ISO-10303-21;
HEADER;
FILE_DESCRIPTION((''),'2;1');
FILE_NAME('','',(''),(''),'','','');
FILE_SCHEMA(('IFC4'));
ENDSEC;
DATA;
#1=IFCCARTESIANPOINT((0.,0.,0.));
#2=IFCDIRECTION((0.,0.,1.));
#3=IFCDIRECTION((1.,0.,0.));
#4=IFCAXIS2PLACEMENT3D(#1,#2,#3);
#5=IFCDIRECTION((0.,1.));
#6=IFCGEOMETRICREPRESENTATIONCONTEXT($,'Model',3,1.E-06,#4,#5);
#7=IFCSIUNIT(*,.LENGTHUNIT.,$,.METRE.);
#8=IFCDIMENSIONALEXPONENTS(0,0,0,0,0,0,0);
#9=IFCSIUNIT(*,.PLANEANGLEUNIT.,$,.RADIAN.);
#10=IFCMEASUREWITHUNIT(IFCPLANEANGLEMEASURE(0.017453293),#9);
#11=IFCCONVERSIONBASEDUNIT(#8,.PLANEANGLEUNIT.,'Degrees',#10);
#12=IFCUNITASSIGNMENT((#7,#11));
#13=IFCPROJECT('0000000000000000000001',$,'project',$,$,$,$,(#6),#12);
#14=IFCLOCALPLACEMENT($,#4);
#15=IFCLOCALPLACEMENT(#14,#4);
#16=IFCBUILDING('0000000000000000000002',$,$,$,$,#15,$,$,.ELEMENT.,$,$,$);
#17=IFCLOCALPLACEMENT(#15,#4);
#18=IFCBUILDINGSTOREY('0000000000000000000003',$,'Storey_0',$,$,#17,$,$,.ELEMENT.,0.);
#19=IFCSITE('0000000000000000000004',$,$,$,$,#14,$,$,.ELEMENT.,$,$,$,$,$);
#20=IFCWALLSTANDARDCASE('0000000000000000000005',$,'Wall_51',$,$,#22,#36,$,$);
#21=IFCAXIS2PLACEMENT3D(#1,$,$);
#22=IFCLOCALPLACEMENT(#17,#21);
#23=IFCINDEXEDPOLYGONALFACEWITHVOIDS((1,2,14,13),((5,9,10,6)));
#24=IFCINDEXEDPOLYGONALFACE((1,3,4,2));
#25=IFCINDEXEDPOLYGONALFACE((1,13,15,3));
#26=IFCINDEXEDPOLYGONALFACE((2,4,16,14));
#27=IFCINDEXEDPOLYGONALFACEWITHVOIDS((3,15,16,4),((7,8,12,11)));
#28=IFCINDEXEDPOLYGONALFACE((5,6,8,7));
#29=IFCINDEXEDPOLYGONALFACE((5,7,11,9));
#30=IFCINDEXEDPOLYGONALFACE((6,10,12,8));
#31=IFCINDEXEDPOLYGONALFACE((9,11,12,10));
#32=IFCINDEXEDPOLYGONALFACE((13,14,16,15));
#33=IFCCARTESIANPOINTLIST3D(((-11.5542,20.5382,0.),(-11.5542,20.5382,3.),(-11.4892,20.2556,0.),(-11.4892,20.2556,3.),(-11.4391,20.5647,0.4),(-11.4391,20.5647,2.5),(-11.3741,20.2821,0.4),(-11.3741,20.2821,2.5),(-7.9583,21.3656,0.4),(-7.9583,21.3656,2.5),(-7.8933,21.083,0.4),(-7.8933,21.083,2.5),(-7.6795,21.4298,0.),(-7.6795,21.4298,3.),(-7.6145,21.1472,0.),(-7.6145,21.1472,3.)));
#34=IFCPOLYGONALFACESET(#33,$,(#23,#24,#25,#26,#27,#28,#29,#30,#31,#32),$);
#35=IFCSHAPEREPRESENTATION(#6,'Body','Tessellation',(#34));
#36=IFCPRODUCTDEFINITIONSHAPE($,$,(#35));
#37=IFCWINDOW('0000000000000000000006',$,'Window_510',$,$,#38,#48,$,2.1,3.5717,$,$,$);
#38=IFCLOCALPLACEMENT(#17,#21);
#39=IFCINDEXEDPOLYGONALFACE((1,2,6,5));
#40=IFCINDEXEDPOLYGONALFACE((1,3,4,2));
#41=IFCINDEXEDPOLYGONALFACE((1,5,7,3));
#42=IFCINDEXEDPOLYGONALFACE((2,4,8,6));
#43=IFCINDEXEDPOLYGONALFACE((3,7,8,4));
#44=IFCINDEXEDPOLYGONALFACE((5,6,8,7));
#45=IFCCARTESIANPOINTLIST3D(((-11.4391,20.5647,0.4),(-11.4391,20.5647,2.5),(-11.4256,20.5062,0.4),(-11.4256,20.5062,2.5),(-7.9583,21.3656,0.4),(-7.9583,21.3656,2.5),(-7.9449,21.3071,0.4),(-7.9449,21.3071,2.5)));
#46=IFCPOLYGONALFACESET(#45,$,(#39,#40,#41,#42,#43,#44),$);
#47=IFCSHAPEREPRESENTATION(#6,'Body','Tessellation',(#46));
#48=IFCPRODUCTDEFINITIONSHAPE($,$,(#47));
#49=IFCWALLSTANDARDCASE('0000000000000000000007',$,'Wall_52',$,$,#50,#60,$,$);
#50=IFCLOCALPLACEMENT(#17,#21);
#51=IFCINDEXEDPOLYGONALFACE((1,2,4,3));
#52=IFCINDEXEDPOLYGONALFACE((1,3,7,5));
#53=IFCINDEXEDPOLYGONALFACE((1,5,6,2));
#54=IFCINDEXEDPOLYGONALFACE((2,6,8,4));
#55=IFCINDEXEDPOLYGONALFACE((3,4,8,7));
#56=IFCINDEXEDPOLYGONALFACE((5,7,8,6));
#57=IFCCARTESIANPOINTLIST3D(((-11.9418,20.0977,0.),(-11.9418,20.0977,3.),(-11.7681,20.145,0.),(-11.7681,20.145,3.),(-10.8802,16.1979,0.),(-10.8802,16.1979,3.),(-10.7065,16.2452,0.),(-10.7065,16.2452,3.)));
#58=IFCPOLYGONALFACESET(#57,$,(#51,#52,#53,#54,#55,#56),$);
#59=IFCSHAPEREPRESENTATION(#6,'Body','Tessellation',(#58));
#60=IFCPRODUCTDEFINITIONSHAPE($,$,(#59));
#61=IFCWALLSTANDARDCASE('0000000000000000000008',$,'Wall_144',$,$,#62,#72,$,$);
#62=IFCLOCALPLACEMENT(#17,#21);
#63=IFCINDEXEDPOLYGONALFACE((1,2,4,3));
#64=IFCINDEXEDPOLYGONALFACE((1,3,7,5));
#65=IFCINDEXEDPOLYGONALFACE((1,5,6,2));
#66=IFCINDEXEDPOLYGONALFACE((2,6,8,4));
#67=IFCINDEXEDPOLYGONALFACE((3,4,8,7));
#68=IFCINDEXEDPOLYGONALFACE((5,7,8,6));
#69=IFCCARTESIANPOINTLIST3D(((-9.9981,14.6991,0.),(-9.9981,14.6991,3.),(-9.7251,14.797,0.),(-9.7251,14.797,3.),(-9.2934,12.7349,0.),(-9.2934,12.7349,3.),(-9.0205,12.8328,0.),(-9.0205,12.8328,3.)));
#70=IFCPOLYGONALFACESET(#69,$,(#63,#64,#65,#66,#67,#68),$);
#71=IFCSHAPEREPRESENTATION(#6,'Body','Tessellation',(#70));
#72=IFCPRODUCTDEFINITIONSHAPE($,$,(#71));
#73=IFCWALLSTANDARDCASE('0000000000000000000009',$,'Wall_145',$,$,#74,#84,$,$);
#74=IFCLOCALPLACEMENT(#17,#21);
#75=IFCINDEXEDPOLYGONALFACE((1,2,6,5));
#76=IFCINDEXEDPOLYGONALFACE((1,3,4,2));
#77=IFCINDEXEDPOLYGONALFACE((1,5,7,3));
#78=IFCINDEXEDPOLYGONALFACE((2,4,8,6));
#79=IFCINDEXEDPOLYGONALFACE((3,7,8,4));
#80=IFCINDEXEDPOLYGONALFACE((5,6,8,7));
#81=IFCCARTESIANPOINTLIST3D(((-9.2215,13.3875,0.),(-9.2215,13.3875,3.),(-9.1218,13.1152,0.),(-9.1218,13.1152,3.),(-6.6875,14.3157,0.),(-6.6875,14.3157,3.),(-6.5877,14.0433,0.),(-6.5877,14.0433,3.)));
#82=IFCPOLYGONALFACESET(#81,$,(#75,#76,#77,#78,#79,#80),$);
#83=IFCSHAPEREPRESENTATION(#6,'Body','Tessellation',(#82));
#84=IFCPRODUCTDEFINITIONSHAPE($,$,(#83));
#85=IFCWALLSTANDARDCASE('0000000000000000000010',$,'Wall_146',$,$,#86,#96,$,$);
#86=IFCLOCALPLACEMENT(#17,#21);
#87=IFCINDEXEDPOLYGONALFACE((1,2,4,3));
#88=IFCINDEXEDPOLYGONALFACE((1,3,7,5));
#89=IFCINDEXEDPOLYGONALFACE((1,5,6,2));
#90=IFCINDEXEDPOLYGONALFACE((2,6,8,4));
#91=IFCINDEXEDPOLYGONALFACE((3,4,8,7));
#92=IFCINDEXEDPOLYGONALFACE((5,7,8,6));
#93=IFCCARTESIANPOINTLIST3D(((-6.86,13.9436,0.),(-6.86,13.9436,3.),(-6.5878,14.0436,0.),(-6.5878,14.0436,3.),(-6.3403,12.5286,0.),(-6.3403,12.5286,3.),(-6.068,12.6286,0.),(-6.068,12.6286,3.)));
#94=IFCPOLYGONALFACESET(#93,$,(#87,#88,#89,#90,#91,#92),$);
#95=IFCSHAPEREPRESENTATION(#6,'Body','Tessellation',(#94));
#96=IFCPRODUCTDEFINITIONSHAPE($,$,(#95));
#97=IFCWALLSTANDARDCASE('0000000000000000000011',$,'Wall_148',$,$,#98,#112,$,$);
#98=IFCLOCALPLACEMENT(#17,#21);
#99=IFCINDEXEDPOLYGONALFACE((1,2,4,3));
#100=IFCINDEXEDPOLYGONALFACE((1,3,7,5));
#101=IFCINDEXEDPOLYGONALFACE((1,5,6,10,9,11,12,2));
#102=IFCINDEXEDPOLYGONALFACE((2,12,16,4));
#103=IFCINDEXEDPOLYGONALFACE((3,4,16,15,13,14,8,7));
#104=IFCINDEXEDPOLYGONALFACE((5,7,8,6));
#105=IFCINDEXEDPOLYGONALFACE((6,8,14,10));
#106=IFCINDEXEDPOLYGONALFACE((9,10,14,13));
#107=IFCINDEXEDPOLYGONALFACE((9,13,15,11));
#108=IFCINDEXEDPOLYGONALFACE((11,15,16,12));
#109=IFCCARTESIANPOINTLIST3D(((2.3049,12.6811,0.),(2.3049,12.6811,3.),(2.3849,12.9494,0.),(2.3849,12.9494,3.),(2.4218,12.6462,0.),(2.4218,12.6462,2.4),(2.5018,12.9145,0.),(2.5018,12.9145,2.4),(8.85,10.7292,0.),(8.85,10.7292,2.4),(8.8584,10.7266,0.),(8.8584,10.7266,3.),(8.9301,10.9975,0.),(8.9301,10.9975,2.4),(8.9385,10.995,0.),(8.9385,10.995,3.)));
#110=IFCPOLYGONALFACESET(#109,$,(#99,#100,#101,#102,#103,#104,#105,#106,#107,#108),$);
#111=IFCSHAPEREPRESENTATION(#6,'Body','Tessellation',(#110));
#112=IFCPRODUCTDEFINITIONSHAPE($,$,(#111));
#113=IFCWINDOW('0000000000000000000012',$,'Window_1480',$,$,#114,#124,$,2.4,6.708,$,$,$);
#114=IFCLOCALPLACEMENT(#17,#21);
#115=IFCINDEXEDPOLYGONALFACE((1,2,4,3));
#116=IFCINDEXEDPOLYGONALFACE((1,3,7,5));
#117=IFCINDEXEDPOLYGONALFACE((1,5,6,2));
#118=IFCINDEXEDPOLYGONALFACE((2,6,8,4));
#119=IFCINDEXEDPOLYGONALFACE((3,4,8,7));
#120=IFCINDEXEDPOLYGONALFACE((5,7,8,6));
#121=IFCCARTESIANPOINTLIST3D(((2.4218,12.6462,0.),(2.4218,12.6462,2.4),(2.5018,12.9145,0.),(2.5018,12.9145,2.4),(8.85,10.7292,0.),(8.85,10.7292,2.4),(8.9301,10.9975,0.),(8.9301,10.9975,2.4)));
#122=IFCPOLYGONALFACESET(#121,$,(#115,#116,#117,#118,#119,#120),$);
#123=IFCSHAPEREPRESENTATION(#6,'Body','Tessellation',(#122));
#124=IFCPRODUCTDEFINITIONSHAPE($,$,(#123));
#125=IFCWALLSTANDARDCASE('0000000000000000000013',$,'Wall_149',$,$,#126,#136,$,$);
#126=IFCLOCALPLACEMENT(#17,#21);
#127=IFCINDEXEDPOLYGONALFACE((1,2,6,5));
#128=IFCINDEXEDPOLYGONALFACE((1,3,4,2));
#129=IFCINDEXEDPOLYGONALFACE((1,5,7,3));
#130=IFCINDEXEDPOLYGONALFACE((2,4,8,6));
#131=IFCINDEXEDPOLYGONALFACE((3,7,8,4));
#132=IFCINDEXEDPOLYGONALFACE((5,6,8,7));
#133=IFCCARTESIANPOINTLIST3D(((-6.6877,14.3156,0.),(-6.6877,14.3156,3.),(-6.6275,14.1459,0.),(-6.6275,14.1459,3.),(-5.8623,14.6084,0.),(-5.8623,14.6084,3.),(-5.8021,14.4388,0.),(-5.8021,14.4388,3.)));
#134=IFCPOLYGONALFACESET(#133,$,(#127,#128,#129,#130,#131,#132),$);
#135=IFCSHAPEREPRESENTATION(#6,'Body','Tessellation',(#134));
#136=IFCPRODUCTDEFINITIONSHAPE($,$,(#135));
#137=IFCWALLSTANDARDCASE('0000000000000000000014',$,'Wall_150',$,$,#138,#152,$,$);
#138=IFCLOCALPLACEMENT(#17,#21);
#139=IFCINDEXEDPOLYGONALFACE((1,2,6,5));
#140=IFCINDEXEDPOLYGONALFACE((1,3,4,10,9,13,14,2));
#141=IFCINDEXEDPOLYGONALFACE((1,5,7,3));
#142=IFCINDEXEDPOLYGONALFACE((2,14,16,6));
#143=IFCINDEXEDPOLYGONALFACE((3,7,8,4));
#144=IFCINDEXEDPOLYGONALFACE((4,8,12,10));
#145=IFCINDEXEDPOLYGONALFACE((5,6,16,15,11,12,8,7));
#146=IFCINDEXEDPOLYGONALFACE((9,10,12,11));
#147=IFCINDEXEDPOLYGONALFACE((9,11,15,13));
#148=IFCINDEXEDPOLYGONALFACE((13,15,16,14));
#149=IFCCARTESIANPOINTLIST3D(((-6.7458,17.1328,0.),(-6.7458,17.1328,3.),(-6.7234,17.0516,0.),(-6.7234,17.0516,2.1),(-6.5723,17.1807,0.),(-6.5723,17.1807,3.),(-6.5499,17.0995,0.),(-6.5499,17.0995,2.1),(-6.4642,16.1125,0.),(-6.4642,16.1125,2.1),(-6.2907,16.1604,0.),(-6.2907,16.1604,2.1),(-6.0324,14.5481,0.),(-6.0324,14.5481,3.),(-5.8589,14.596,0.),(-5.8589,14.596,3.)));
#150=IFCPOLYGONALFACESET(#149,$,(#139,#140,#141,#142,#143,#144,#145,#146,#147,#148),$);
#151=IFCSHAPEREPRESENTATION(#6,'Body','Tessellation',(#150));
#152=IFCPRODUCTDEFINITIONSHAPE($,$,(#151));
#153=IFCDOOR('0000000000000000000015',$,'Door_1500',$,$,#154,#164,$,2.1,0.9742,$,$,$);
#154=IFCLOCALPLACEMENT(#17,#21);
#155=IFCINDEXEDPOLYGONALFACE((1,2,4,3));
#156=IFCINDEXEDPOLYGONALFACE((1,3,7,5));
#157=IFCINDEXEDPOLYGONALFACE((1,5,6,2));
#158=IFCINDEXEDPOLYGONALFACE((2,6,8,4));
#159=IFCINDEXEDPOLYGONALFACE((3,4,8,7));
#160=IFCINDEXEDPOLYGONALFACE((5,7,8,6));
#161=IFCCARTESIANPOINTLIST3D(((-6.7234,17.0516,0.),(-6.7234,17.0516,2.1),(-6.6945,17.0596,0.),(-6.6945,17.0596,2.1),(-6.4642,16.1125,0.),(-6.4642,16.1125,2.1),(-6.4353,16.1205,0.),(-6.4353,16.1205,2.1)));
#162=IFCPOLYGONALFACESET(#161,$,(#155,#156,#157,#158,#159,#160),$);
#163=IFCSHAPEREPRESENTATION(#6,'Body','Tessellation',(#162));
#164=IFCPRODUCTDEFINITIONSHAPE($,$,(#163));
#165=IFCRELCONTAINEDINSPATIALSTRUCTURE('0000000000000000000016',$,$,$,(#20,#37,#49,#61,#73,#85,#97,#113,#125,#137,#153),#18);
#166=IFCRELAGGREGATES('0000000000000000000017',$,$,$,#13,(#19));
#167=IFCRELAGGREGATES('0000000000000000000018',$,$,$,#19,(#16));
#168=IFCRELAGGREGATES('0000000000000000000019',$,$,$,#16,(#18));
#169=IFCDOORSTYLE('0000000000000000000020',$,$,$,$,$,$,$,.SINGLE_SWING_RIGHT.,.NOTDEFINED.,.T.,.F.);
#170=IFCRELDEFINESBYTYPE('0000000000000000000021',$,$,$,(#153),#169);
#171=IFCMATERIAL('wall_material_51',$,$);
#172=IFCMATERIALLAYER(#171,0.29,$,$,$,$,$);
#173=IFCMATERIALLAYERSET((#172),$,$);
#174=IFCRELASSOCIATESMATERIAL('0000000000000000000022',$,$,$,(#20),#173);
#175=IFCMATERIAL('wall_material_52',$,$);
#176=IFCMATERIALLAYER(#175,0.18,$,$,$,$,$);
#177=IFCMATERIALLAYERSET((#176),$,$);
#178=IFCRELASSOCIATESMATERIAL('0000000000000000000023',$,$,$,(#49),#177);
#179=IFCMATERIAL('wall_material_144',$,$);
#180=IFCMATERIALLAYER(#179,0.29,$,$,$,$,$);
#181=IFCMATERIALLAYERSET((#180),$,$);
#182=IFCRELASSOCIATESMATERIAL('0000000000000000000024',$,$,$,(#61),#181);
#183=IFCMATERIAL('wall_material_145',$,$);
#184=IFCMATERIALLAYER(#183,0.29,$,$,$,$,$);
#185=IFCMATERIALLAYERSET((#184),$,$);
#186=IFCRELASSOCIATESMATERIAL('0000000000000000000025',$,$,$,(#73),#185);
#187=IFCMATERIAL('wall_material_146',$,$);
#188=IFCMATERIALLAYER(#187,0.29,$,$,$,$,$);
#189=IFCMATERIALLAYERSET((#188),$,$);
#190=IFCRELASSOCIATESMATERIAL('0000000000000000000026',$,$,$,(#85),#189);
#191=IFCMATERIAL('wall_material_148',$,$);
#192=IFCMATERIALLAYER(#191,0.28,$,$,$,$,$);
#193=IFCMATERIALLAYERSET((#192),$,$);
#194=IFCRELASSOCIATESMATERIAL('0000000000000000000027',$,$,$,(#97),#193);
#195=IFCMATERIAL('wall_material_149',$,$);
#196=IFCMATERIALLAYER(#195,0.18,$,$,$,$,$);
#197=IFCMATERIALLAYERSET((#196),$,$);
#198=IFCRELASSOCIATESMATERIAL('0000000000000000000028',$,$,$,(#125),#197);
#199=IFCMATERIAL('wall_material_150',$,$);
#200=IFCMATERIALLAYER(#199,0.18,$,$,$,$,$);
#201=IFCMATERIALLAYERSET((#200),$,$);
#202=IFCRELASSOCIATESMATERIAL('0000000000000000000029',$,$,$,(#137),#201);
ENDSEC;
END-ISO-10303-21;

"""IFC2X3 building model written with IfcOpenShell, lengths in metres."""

from ifc_helpers import new_model, entity, si_unit, converted_unit, direction, frame, frame_2d, origin_with_axes, place, context, project, spatial, polyline, rectangle, outline, extrude, material, layer, layer_set, layer_usage, type_object, element, fill, save


model = new_model("IFC2X3")

# Units and contexts
model_context = context("Model", 3, precision=1e-06, world=origin_with_axes(), true_north=direction((0.0, 1.0)))
ifc_project = project(units=[si_unit("LENGTHUNIT", "METRE"), converted_unit("PLANEANGLEUNIT", "Degrees", entity("IfcPlaneAngleMeasure", 0.017453293), si_unit("PLANEANGLEUNIT", "RADIAN"), dimensions=[0, 0, 0, 0, 0, 0, 0])], contexts=[model_context])

# Site, building, storey
site_placement = place(None, origin_with_axes())
site = spatial("IfcSite", under=ifc_project, at=site_placement, CompositionType="ELEMENT")
building_placement = place(site_placement, origin_with_axes())
building = spatial("IfcBuilding", under=site, at=building_placement, CompositionType="ELEMENT")
storey_placement = place(building_placement, origin_with_axes())
storey = spatial("IfcBuildingStorey", under=building, at=storey_placement, Name="Storey_0", CompositionType="ELEMENT", Elevation=0.0)

# Wall, opening, window
ifc_material_1 = material(Name="wall_material_51")
ifc_layer_1 = layer(ifc_material_1, 0.29)
ifc_layer_set_1 = layer_set([ifc_layer_1])
ifc_layer_usage_1 = layer_usage(ifc_layer_set_1, "AXIS2", "NEGATIVE", 0.0)
wall_1_placement = place(storey_placement, frame((-11.5542, 20.5382, 0.0), z_axis=(0.0, 0.0, 1.0), x_axis=(0.974534, 0.22424, 0.0)))
wall_1 = element("IfcWallStandardCase", 1, at=wall_1_placement, inside=storey, material=ifc_layer_usage_1, Name="Wall_51", context=model_context, shape_type="SweptSolid", body=[
    extrude(outline(polyline([(0.0, 0.0), (3.9759, 0.0), (3.9759, -0.29), (0.0, -0.29), (0.0, 0.0)])), origin_with_axes(), (0.0, 0.0, 1.0), 3.0),
])
opening_1_placement = place(wall_1_placement, frame((0.1181, 0.0, 0.4), z_axis=(0.0, 0.0, 1.0), x_axis=(1.0, 0.0, 0.0)))
opening_1 = element("IfcOpeningElement", 2, at=opening_1_placement, cuts=wall_1, context=model_context, shape_type="SweptSolid", body=[
    extrude(rectangle(XDim=3.5717, YDim=2.1, at=frame_2d((1.05, -1.7859), x_axis=(0.0, 1.0))), frame((0.0, 0.01, 0.0), z_axis=(0.0, -1.0, 0.0), x_axis=(0.0, 0.0, 1.0)), (0.0, 0.0, 1.0), 0.31),
])
window_1_placement = place(storey_placement, frame((0.0, 0.0, 0.4), z_axis=(0.0, 0.0, 1.0), x_axis=(1.0, 0.0, 0.0)))
window_1 = element("IfcWindow", 3, at=window_1_placement, inside=storey, Name="Window_510", OverallHeight=2.1, OverallWidth=3.5717, context=model_context, shape_type="SweptSolid", body=[
    extrude(outline(polyline([(-11.4391, 20.5647), (-7.9583, 21.3656), (-7.9449, 21.3071), (-11.4256, 20.5062), (-11.4391, 20.5647)])), origin_with_axes(), (0.0, 0.0, 1.0), 2.1),
])
fill(opening_1, window_1)

# Walls
ifc_material_2 = material(Name="wall_material_52")
ifc_layer_2 = layer(ifc_material_2, 0.18)
ifc_layer_set_2 = layer_set([ifc_layer_2])
ifc_layer_usage_2 = layer_usage(ifc_layer_set_2, "AXIS2", "POSITIVE", 0.0)
wall_2_placement = place(storey_placement, frame((-11.9418, 20.0977, 0.0), z_axis=(0.0, 0.0, 1.0), x_axis=(0.262665, -0.964887, 0.0)))
element("IfcWallStandardCase", 4, at=wall_2_placement, inside=storey, material=ifc_layer_usage_2, Name="Wall_52", context=model_context, shape_type="SweptSolid", body=[
    extrude(outline(polyline([(0.0, 0.18), (4.0417, 0.18), (4.0417, 0.0), (0.0, 0.0), (0.0, 0.18)])), origin_with_axes(), (0.0, 0.0, 1.0), 3.0),
])
ifc_material_3 = material(Name="wall_material_144")
ifc_layer_3 = layer(ifc_material_3, 0.29)
ifc_layer_set_3 = layer_set([ifc_layer_3])
ifc_layer_usage_3 = layer_usage(ifc_layer_set_3, "AXIS2", "NEGATIVE", 0.0)
wall_3_placement = place(storey_placement, frame((-9.7251, 14.797, 0.0), z_axis=(0.0, 0.0, 1.0), x_axis=(0.337694, -0.941256, 0.0)))
element("IfcWallStandardCase", 5, at=wall_3_placement, inside=storey, material=ifc_layer_usage_3, Name="Wall_144", context=model_context, shape_type="SweptSolid", body=[
    extrude(outline(polyline([(0.0, 0.0), (2.0867, 0.0), (2.0867, -0.29), (0.0, -0.29), (0.0, 0.0)])), origin_with_axes(), (0.0, 0.0, 1.0), 3.0),
])
ifc_material_4 = material(Name="wall_material_145")
ifc_layer_4 = layer(ifc_material_4, 0.29)
ifc_layer_set_4 = layer_set([ifc_layer_4])
ifc_layer_usage_4 = layer_usage(ifc_layer_set_4, "AXIS2", "NEGATIVE", 0.0)
wall_4_placement = place(storey_placement, frame((-9.2215, 13.3875, 0.0), z_axis=(0.0, 0.0, 1.0), x_axis=(0.939, 0.343918, 0.0)))
element("IfcWallStandardCase", 6, at=wall_4_placement, inside=storey, material=ifc_layer_usage_4, Name="Wall_145", context=model_context, shape_type="SweptSolid", body=[
    extrude(outline(polyline([(0.0, 0.0), (2.6987, 0.0), (2.6987, -0.29), (0.0, -0.29), (0.0, 0.0)])), origin_with_axes(), (0.0, 0.0, 1.0), 3.0),
])
ifc_material_5 = material(Name="wall_material_146")
ifc_layer_5 = layer(ifc_material_5, 0.29)
ifc_layer_set_5 = layer_set([ifc_layer_5])
ifc_layer_usage_5 = layer_usage(ifc_layer_set_5, "AXIS2", "NEGATIVE", 0.0)
wall_5_placement = place(storey_placement, frame((-6.5878, 14.0436, 0.0), z_axis=(0.0, 0.0, 1.0), x_axis=(0.344806, -0.938674, 0.0)))
element("IfcWallStandardCase", 7, at=wall_5_placement, inside=storey, material=ifc_layer_usage_5, Name="Wall_146", context=model_context, shape_type="SweptSolid", body=[
    extrude(outline(polyline([(0.0, 0.0), (1.5075, 0.0), (1.5075, -0.29), (0.0, -0.29), (0.0, 0.0)])), origin_with_axes(), (0.0, 0.0, 1.0), 3.0),
])

# Wall, opening, window
ifc_material_6 = material(Name="wall_material_148")
ifc_layer_6 = layer(ifc_material_6, 0.28)
ifc_layer_set_6 = layer_set([ifc_layer_6])
ifc_layer_usage_6 = layer_usage(ifc_layer_set_6, "AXIS2", "NEGATIVE", 0.0)
wall_6_placement = place(storey_placement, frame((2.3849, 12.9494, 0.0), z_axis=(0.0, 0.0, 1.0), x_axis=(0.958294, -0.285783, 0.0)))
wall_6 = element("IfcWallStandardCase", 8, at=wall_6_placement, inside=storey, material=ifc_layer_usage_6, Name="Wall_148", context=model_context, shape_type="SweptSolid", body=[
    extrude(outline(polyline([(0.0, 0.0), (6.8388, 0.0), (6.8388, -0.28), (0.0, -0.28), (0.0, 0.0)])), origin_with_axes(), (0.0, 0.0, 1.0), 3.0),
])
opening_2_placement = place(wall_6_placement, frame((0.122, 0.0, 0.0), z_axis=(0.0, 0.0, 1.0), x_axis=(1.0, 0.0, 0.0)))
opening_2 = element("IfcOpeningElement", 9, at=opening_2_placement, cuts=wall_6, context=model_context, shape_type="SweptSolid", body=[
    extrude(rectangle(XDim=6.708, YDim=2.4, at=frame_2d((1.2, -3.354), x_axis=(0.0, 1.0))), frame((0.0, 0.01, 0.0), z_axis=(0.0, -1.0, 0.0), x_axis=(0.0, 0.0, 1.0)), (0.0, 0.0, 1.0), 0.3),
])
window_2_placement = place(storey_placement, origin_with_axes())
window_2 = element("IfcWindow", 10, at=window_2_placement, inside=storey, Name="Window_1480", OverallHeight=2.4, OverallWidth=6.708, context=model_context, shape_type="SweptSolid", body=[
    extrude(outline(polyline([(2.5018, 12.9145), (8.9301, 10.9975), (8.85, 10.7292), (2.4218, 12.6462), (2.5018, 12.9145)])), origin_with_axes(), (0.0, 0.0, 1.0), 2.4),
])
fill(opening_2, window_2)

# Wall
ifc_material_7 = material(Name="wall_material_149")
ifc_layer_7 = layer(ifc_material_7, 0.18)
ifc_layer_set_7 = layer_set([ifc_layer_7])
ifc_layer_usage_7 = layer_usage(ifc_layer_set_7, "AXIS2", "NEGATIVE", 0.0)
wall_7_placement = place(storey_placement, frame((-6.6877, 14.3156, 0.0), z_axis=(0.0, 0.0, 1.0), x_axis=(0.942433, 0.334395, 0.0)))
element("IfcWallStandardCase", 11, at=wall_7_placement, inside=storey, material=ifc_layer_usage_7, Name="Wall_149", context=model_context, shape_type="SweptSolid", body=[
    extrude(outline(polyline([(0.0, 0.0), (0.8758, 0.0), (0.8758, -0.18), (0.0, -0.18), (0.0, 0.0)])), origin_with_axes(), (0.0, 0.0, 1.0), 3.0),
])

# Wall, opening, door
ifc_material_8 = material(Name="wall_material_150")
ifc_layer_8 = layer(ifc_material_8, 0.18)
ifc_layer_set_8 = layer_set([ifc_layer_8])
ifc_layer_usage_8 = layer_usage(ifc_layer_set_8, "AXIS2", "POSITIVE", 0.0)
wall_8_placement = place(storey_placement, frame((-5.8589, 14.596, 0.0), z_axis=(0.0, 0.0, 1.0), x_axis=(-0.266055, 0.963958, 0.0)))
wall_8 = element("IfcWallStandardCase", 12, at=wall_8_placement, inside=storey, material=ifc_layer_usage_8, Name="Wall_150", context=model_context, shape_type="SweptSolid", body=[
    extrude(outline(polyline([(0.0, 0.18), (2.6813, 0.18), (2.6813, 0.0), (0.0, 0.0), (0.0, 0.18)])), origin_with_axes(), (0.0, 0.0, 1.0), 3.0),
])
opening_3_placement = place(wall_8_placement, frame((1.6229, 0.18, 0.0), z_axis=(0.0, 0.0, 1.0), x_axis=(1.0, 0.0, 0.0)))
opening_3 = element("IfcOpeningElement", 13, at=opening_3_placement, cuts=wall_8, context=model_context, shape_type="SweptSolid", body=[
    extrude(rectangle(XDim=0.9742, YDim=2.1, at=frame_2d((1.05, -0.4871), x_axis=(0.0, 1.0))), frame((0.0, 0.01, 0.0), z_axis=(0.0, -1.0, 0.0), x_axis=(0.0, 0.0, 1.0)), (0.0, 0.0, 1.0), 0.2),
])
door_style_1 = type_object("IfcDoorStyle", ConstructionType="NOTDEFINED", OperationType="SINGLE_SWING_RIGHT", ParameterTakesPrecedence=True, Sizeable=False)
door_1_placement = place(storey_placement, origin_with_axes())
door_1 = element("IfcDoor", 14, at=door_1_placement, inside=storey, type_object=door_style_1, Name="Door_1500", OverallHeight=2.1, OverallWidth=0.9742, context=model_context, shape_type="SweptSolid", body=[
    extrude(outline(polyline([(-6.4642, 16.1125), (-6.7234, 17.0516), (-6.6945, 17.0596), (-6.4353, 16.1205), (-6.4642, 16.1125)])), origin_with_axes(), (0.0, 0.0, 1.0), 2.1),
])
fill(opening_3, door_1)

save(model, "model.ifc")
